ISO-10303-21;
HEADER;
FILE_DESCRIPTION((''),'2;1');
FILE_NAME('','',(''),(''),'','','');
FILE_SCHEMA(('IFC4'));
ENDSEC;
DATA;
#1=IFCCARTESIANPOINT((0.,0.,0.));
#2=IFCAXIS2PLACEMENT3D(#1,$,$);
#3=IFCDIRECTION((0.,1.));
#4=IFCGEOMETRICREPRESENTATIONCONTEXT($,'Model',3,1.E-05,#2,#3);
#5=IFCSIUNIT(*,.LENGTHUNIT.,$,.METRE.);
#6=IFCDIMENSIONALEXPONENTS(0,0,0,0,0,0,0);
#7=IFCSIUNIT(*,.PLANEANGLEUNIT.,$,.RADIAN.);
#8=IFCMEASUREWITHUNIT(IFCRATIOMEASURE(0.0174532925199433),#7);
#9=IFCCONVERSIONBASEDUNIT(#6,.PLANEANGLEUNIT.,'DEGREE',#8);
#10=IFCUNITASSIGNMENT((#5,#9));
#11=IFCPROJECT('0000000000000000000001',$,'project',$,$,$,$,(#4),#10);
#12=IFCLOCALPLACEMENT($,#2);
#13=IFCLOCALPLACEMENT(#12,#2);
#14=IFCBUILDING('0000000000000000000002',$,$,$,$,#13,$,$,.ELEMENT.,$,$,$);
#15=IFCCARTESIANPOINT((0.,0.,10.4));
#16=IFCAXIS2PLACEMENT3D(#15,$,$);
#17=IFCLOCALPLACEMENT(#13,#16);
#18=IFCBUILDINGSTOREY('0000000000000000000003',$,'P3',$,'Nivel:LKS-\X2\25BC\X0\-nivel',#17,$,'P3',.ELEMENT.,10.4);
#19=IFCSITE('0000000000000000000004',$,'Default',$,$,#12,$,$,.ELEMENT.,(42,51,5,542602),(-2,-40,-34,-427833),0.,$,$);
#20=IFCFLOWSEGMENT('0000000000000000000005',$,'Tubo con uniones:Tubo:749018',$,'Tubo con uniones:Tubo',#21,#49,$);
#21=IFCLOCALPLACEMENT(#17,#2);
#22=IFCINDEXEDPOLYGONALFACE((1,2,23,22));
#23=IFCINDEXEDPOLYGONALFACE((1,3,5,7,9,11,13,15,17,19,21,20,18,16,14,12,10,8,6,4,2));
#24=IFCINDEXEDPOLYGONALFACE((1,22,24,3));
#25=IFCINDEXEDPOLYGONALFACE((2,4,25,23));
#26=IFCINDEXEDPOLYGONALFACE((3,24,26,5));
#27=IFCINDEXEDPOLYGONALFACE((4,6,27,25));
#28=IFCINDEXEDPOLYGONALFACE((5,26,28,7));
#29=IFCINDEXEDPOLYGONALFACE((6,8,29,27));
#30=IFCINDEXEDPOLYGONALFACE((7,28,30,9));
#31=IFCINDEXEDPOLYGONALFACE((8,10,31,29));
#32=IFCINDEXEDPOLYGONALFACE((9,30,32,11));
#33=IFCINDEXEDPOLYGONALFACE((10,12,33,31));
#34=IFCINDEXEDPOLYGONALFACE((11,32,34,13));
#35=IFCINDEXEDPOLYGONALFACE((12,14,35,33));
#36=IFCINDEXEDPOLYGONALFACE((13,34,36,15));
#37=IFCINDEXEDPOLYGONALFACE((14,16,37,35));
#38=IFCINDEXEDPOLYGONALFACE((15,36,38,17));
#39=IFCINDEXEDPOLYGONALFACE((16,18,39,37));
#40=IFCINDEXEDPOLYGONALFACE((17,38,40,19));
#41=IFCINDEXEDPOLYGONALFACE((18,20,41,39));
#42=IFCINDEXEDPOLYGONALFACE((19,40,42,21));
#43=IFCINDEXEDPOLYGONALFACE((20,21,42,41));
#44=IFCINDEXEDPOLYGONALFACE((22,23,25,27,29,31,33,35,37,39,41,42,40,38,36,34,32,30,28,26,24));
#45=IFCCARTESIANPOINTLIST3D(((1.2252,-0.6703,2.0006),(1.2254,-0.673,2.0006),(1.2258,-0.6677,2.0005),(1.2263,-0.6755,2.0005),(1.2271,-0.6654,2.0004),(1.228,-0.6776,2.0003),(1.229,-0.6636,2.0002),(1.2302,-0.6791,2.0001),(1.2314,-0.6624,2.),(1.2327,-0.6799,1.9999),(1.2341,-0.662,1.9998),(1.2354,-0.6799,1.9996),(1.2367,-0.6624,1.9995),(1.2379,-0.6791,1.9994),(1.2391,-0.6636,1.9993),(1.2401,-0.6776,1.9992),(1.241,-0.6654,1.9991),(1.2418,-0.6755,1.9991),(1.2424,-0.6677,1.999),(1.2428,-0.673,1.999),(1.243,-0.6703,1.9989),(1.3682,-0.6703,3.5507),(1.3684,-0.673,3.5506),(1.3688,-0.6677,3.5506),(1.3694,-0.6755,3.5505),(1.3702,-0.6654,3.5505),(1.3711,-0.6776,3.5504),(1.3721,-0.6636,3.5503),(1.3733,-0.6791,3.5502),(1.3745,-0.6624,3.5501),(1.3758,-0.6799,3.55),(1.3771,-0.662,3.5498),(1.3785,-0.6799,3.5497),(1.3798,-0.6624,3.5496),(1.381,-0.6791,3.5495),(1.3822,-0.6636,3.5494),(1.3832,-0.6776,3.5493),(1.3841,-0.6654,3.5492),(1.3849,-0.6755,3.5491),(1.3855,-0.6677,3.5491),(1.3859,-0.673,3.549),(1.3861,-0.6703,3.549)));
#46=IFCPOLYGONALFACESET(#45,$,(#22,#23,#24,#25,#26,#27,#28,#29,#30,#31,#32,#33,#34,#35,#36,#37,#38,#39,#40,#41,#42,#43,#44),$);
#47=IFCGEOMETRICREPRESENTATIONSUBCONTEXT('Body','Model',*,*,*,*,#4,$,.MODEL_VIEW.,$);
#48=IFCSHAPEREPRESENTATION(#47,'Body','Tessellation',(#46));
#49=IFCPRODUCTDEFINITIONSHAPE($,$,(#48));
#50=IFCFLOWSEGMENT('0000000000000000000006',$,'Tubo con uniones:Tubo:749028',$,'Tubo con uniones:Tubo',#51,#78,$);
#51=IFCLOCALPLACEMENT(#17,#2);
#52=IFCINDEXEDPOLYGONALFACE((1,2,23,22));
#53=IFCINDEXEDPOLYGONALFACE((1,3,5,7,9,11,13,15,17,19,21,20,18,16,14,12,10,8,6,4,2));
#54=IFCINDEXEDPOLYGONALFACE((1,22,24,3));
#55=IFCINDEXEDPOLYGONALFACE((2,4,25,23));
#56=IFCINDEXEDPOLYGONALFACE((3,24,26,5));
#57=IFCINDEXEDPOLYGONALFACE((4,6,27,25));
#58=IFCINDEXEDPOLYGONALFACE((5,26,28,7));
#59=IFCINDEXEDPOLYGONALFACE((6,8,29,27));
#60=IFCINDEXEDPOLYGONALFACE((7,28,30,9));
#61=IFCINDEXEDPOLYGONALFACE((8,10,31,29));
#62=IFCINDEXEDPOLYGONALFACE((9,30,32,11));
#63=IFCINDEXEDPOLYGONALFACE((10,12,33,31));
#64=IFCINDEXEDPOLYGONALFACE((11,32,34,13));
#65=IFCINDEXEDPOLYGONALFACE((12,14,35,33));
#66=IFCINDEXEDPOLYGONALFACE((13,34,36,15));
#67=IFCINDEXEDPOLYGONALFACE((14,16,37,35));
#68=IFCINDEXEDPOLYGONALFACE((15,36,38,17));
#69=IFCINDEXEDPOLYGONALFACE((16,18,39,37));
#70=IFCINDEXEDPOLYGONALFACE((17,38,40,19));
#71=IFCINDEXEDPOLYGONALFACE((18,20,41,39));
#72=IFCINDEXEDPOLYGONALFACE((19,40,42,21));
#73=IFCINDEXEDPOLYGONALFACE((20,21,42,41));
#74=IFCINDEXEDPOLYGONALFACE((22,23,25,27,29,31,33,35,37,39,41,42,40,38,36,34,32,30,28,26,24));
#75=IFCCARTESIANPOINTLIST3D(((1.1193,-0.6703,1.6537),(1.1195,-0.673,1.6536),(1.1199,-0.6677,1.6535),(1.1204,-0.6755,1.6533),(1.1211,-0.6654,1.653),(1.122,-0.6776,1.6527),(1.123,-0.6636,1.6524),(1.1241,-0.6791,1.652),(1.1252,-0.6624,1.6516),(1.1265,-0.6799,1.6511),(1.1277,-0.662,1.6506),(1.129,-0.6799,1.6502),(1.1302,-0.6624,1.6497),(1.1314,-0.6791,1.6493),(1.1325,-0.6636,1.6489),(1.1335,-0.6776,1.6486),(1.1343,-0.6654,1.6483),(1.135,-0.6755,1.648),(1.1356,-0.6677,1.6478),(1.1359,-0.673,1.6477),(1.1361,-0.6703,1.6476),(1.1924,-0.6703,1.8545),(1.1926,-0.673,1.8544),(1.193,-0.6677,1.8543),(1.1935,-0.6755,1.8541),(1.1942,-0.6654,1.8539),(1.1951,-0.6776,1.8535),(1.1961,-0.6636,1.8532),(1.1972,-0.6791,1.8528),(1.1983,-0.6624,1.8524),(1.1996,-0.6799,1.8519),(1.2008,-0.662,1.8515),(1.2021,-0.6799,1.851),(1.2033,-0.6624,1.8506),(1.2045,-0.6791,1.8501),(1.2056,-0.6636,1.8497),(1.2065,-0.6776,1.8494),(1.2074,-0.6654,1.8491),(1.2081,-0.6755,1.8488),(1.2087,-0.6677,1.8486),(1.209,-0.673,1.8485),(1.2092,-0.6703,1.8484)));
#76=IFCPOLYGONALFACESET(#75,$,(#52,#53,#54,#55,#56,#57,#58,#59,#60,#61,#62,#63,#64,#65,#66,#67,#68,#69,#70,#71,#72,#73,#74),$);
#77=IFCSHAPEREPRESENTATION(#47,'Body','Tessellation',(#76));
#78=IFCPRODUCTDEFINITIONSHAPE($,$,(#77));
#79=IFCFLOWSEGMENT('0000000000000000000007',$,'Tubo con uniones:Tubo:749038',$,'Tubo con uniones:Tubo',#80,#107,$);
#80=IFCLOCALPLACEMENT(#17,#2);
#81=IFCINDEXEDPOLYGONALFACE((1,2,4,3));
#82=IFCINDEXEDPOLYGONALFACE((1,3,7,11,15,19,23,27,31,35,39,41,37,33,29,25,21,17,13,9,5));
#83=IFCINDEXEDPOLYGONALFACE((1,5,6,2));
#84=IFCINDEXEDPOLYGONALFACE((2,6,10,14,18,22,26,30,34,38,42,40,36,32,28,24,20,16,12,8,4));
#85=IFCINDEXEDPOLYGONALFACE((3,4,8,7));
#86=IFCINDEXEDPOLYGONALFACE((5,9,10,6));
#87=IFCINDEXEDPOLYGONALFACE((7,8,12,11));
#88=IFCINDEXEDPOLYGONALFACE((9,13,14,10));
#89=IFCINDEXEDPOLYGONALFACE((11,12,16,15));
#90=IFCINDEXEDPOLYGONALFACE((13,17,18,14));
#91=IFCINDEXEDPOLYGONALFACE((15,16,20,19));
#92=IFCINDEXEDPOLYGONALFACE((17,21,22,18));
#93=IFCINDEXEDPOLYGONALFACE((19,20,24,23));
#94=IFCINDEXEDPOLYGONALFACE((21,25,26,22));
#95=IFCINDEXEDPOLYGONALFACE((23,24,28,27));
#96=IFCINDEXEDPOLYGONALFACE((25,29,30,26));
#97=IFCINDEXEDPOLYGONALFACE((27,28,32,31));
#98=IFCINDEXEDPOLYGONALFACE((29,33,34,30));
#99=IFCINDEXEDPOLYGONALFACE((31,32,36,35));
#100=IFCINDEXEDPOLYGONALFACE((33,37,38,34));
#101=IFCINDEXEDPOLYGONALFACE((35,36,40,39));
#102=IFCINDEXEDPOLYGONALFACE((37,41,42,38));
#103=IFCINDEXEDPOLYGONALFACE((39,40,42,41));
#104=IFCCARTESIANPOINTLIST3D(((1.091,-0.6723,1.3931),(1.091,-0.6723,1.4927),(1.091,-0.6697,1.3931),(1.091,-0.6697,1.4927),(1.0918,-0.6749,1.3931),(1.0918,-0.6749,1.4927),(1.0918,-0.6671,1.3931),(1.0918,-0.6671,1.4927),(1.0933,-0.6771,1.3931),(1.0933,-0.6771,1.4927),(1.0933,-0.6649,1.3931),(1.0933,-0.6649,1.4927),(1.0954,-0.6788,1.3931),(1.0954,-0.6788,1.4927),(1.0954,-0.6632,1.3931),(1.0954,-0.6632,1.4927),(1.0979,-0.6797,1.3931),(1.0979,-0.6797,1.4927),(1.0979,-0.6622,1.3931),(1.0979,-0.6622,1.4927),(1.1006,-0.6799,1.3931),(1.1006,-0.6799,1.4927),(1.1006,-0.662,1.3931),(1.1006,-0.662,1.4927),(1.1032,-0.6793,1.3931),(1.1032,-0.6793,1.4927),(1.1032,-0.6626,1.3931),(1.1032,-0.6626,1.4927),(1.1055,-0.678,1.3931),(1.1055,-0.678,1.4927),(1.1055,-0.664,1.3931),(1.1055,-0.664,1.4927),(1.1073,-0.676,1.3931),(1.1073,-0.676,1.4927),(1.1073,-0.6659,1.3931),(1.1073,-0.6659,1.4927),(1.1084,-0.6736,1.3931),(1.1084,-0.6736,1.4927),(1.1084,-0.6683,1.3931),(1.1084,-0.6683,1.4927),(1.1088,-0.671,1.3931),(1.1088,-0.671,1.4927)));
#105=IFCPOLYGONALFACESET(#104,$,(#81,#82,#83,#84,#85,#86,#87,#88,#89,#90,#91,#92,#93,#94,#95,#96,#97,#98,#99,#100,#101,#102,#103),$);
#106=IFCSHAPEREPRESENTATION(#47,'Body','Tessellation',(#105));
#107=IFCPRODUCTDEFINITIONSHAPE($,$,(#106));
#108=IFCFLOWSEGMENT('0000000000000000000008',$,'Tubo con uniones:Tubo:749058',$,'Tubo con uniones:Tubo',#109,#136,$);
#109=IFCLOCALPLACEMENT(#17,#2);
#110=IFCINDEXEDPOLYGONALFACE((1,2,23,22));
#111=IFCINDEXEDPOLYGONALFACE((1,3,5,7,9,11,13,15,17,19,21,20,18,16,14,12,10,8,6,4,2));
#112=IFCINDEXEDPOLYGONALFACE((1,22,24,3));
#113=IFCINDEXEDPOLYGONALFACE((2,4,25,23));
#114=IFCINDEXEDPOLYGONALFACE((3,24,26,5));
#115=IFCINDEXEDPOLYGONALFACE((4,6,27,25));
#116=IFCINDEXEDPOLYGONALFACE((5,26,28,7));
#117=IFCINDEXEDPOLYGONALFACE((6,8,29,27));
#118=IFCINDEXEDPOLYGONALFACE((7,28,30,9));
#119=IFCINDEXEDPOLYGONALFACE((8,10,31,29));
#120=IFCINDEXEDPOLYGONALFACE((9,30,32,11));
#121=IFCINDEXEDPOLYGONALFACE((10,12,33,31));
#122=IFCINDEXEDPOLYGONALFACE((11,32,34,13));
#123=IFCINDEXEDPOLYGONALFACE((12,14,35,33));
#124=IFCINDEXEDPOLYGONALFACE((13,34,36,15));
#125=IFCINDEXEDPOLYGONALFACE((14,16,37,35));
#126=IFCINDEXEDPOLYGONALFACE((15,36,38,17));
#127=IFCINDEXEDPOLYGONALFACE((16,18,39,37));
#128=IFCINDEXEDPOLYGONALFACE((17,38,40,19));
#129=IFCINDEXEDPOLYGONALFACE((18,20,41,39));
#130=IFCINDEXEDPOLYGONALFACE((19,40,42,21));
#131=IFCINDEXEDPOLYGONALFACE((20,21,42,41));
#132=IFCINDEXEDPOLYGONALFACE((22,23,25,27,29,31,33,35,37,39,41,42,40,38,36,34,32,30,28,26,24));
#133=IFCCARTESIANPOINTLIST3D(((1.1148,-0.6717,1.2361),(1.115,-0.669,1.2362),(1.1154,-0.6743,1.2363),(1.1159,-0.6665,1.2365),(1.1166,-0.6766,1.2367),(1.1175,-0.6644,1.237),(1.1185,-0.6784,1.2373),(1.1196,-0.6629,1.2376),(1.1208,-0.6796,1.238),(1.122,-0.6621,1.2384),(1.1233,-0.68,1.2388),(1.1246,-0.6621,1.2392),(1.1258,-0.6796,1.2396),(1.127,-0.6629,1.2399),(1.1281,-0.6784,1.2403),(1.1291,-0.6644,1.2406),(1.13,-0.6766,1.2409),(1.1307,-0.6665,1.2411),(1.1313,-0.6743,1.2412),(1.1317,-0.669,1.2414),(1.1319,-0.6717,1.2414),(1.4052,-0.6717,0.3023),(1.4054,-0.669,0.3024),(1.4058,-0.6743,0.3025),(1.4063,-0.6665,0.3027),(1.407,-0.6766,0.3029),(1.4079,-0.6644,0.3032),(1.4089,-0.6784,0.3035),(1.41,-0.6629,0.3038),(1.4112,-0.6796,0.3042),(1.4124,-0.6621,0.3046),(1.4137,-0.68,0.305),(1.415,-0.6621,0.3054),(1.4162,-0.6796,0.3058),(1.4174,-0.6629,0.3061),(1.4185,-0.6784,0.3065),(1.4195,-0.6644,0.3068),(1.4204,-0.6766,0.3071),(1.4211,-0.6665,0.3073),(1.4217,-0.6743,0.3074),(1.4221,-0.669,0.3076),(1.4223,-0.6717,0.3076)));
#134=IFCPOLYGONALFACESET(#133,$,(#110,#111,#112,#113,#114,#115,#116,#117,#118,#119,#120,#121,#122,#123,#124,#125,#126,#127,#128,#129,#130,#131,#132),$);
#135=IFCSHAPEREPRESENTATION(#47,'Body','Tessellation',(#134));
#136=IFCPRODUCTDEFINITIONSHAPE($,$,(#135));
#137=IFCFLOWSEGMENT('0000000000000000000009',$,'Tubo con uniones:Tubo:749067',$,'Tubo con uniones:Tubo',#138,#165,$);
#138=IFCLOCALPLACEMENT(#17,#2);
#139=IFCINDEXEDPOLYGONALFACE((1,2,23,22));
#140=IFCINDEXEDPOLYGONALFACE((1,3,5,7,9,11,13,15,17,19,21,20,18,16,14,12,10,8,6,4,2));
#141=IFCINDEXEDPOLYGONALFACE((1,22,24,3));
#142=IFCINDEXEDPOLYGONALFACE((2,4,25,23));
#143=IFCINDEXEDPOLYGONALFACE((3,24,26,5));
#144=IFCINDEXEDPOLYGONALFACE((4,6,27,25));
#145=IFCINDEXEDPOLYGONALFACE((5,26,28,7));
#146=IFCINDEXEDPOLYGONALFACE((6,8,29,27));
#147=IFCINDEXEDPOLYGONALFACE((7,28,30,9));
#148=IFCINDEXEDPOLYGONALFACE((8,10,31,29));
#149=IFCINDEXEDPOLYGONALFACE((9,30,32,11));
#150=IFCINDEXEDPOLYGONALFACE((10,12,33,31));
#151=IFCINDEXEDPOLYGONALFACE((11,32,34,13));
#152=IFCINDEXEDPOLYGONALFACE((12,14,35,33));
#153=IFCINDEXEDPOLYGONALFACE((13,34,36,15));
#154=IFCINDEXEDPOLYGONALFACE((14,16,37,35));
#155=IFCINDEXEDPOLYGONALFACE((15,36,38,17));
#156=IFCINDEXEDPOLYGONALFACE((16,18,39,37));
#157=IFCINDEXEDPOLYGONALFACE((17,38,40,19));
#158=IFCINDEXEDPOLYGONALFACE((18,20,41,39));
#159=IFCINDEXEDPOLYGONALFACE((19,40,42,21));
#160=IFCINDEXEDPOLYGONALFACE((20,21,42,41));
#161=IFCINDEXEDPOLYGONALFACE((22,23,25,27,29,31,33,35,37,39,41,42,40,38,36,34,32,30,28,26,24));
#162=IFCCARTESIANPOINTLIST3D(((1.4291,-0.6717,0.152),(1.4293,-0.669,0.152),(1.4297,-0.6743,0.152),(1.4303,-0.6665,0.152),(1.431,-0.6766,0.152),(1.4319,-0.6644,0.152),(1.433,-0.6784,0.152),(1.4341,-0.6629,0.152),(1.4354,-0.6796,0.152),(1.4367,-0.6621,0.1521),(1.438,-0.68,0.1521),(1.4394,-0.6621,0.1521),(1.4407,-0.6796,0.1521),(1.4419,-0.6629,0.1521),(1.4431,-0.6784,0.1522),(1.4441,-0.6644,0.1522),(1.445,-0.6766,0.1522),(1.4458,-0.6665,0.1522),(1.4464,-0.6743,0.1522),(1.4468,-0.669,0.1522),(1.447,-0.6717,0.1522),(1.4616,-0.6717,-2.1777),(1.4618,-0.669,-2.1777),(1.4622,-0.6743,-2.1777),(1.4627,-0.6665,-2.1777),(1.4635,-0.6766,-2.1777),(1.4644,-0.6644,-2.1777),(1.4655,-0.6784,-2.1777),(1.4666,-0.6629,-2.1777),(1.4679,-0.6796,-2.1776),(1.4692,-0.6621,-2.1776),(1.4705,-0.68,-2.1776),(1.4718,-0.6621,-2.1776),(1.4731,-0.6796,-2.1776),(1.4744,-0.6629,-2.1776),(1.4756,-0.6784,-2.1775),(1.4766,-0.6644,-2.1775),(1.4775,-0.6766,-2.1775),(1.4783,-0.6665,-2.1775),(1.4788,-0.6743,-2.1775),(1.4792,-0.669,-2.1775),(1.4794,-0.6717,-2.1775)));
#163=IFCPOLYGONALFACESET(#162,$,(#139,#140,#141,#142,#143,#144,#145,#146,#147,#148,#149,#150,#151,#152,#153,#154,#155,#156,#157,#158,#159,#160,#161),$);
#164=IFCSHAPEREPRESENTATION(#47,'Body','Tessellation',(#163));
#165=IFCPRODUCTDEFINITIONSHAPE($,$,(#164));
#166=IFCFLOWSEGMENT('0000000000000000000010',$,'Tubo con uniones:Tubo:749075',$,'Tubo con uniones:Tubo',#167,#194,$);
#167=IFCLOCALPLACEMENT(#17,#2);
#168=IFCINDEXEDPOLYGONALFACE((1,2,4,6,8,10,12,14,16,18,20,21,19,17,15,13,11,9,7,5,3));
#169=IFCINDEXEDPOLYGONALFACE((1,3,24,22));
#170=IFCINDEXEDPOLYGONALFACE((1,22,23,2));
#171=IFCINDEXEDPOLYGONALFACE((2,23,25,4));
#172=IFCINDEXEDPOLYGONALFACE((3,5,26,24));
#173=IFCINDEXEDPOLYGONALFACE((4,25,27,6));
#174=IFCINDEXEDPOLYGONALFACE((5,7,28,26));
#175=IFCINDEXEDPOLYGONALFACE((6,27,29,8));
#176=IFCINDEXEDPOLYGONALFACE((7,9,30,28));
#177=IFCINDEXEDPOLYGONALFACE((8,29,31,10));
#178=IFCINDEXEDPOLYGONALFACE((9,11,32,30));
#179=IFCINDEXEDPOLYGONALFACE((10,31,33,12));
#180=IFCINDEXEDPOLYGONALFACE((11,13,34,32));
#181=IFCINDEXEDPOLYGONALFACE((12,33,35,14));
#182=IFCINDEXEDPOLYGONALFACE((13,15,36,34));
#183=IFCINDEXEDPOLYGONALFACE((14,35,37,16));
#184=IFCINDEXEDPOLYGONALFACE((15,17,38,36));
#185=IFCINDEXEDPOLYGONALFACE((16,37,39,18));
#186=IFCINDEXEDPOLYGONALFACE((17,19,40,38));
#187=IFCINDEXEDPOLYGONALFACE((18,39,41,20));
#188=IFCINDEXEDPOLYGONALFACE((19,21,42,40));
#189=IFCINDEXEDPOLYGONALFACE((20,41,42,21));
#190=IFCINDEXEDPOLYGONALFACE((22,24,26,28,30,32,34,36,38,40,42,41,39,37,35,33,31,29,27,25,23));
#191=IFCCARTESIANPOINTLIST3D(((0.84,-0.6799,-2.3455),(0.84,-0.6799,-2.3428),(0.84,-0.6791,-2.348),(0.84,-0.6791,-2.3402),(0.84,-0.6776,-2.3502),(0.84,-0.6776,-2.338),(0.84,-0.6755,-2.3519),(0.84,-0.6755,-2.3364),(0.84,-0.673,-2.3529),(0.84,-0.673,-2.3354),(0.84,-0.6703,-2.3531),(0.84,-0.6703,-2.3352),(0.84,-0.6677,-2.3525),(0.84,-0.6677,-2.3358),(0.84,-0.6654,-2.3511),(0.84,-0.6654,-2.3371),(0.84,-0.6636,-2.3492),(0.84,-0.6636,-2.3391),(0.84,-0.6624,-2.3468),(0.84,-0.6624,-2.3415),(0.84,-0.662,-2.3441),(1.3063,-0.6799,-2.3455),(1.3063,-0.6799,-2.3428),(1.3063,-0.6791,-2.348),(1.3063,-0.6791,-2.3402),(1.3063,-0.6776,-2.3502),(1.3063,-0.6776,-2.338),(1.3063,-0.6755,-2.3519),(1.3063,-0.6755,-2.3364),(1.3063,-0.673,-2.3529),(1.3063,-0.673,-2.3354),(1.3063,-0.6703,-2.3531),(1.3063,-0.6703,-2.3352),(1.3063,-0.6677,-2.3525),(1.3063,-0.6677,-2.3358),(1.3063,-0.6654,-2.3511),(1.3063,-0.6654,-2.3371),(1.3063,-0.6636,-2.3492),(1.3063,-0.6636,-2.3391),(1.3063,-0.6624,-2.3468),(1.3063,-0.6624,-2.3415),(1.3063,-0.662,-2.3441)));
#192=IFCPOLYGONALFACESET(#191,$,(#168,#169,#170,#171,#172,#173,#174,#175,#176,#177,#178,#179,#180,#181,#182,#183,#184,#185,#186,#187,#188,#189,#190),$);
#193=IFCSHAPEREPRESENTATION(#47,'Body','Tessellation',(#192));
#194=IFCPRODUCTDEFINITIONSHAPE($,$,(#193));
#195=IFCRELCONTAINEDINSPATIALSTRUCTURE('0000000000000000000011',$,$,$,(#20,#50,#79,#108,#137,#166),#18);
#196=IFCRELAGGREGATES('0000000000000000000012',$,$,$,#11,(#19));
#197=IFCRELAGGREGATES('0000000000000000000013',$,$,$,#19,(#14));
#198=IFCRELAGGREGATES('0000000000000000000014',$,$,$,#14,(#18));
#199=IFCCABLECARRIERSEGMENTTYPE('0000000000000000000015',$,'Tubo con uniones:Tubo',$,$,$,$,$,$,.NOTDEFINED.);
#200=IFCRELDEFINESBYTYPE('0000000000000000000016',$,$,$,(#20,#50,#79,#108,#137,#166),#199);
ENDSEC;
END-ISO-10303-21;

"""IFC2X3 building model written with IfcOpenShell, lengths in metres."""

from ifc_helpers import new_model, entity, si_unit, converted_unit, direction, frame, frame_2d, origin, origin_2d_with_axis, place, context, subcontext, project, spatial, circle, extrude, type_object, element, save


model = new_model("IFC2X3")

# Units and contexts
model_context = context("Model", 3, precision=1e-05, world=origin(), true_north=direction((0.0, 1.0)))
body_context = subcontext(model_context, "Body", "Model", "MODEL_VIEW")
ifc_project = project(units=[si_unit("LENGTHUNIT", "METRE"), converted_unit("PLANEANGLEUNIT", "DEGREE", entity("IfcRatioMeasure", 0.0174532925199433), si_unit("PLANEANGLEUNIT", "RADIAN"), dimensions=[0, 0, 0, 0, 0, 0, 0])], contexts=[model_context])

# Site, building, storey
site_placement = place(None, origin())
site = spatial("IfcSite", under=ifc_project, at=site_placement, Name="Default", CompositionType="ELEMENT", RefLatitude=(42, 51, 5, 542602), RefLongitude=(-2, -40, -34, -427833), RefElevation=0.0)
building_placement = place(site_placement, origin())
building = spatial("IfcBuilding", under=site, at=building_placement, CompositionType="ELEMENT")
storey_placement = place(building_placement, frame((0.0, 0.0, 10.4)))
storey = spatial("IfcBuildingStorey", under=building, at=storey_placement, Name="P3", ObjectType="Nivel:LKS-▼-nivel", LongName="P3", CompositionType="ELEMENT", Elevation=10.4)

# Flow segments
cable_carrier_segment_type = type_object("IfcCableCarrierSegmentType", Name="Tubo con uniones:Tubo", PredefinedType="NOTDEFINED")
flow_segment_1_placement = place(storey_placement, origin())
element("IfcFlowSegment", 1, at=flow_segment_1_placement, inside=storey, type_object=cable_carrier_segment_type, Name="Tubo con uniones:Tubo:749018", ObjectType="Tubo con uniones:Tubo", context=body_context, shape_type="SweptSolid", body=[
    extrude(circle(Radius=0.009, at=frame_2d((0.0, 0.0), x_axis=(1.0, 0.0))), frame((1.2341, -0.671, 1.9998), z_axis=(0.091916, 0.0, 0.995767), x_axis=(0.0, 1.0, 0.0)), (0.0, 0.0, 1.0), 1.5567),
])
flow_segment_2_placement = place(storey_placement, origin())
element("IfcFlowSegment", 2, at=flow_segment_2_placement, inside=storey, type_object=cable_carrier_segment_type, Name="Tubo con uniones:Tubo:749028", ObjectType="Tubo con uniones:Tubo", context=body_context, shape_type="SweptSolid", body=[
    extrude(circle(Radius=0.009, at=frame_2d((0.0, 0.0), x_axis=(1.0, 0.0))), frame((1.1277, -0.671, 1.6506), z_axis=(0.34202, 0.0, 0.939693), x_axis=(0.0, 1.0, 0.0)), (0.0, 0.0, 1.0), 0.2137),
])
flow_segment_3_placement = place(storey_placement, origin())
element("IfcFlowSegment", 3, at=flow_segment_3_placement, inside=storey, type_object=cable_carrier_segment_type, Name="Tubo con uniones:Tubo:749038", ObjectType="Tubo con uniones:Tubo", context=body_context, shape_type="SweptSolid", body=[
    extrude(circle(Radius=0.009, at=frame_2d((0.0, 0.0), x_axis=(1.0, 0.0))), frame((1.0999, -0.671, 1.3931)), (0.0, 0.0, 1.0), 0.0997),
])
flow_segment_4_placement = place(storey_placement, origin())
element("IfcFlowSegment", 4, at=flow_segment_4_placement, inside=storey, type_object=cable_carrier_segment_type, Name="Tubo con uniones:Tubo:749058", ObjectType="Tubo con uniones:Tubo", context=body_context, shape_type="SweptSolid", body=[
    extrude(circle(Radius=0.009, at=frame_2d((0.0, 0.0), x_axis=(1.0, 0.0))), frame((1.4137, -0.671, 0.305), z_axis=(-0.296957, 0.0, 0.954891), x_axis=(0.0, -1.0, 0.0)), (0.0, 0.0, 1.0), 0.9779),
])
flow_segment_5_placement = place(storey_placement, origin())
element("IfcFlowSegment", 5, at=flow_segment_5_placement, inside=storey, type_object=cable_carrier_segment_type, Name="Tubo con uniones:Tubo:749067", ObjectType="Tubo con uniones:Tubo", context=body_context, shape_type="SweptSolid", body=[
    extrude(circle(Radius=0.009, at=origin_2d_with_axis()), frame((1.438, -0.671, 0.1521), z_axis=(0.013935, 0.0, -0.999903), x_axis=(0.0, -1.0, 0.0)), (0.0, 0.0, 1.0), 2.3299),
])
flow_segment_6_placement = place(storey_placement, origin())
element("IfcFlowSegment", 6, at=flow_segment_6_placement, inside=storey, type_object=cable_carrier_segment_type, Name="Tubo con uniones:Tubo:749075", ObjectType="Tubo con uniones:Tubo", context=body_context, shape_type="SweptSolid", body=[
    extrude(circle(Radius=0.009, at=frame_2d((0.0, 0.0), x_axis=(1.0, 0.0))), frame((0.84, -0.671, -2.3441), z_axis=(1.0, 0.0, 0.0), x_axis=(0.0, 1.0, 0.0)), (0.0, 0.0, 1.0), 0.4663),
])

save(model, "model.ifc")
